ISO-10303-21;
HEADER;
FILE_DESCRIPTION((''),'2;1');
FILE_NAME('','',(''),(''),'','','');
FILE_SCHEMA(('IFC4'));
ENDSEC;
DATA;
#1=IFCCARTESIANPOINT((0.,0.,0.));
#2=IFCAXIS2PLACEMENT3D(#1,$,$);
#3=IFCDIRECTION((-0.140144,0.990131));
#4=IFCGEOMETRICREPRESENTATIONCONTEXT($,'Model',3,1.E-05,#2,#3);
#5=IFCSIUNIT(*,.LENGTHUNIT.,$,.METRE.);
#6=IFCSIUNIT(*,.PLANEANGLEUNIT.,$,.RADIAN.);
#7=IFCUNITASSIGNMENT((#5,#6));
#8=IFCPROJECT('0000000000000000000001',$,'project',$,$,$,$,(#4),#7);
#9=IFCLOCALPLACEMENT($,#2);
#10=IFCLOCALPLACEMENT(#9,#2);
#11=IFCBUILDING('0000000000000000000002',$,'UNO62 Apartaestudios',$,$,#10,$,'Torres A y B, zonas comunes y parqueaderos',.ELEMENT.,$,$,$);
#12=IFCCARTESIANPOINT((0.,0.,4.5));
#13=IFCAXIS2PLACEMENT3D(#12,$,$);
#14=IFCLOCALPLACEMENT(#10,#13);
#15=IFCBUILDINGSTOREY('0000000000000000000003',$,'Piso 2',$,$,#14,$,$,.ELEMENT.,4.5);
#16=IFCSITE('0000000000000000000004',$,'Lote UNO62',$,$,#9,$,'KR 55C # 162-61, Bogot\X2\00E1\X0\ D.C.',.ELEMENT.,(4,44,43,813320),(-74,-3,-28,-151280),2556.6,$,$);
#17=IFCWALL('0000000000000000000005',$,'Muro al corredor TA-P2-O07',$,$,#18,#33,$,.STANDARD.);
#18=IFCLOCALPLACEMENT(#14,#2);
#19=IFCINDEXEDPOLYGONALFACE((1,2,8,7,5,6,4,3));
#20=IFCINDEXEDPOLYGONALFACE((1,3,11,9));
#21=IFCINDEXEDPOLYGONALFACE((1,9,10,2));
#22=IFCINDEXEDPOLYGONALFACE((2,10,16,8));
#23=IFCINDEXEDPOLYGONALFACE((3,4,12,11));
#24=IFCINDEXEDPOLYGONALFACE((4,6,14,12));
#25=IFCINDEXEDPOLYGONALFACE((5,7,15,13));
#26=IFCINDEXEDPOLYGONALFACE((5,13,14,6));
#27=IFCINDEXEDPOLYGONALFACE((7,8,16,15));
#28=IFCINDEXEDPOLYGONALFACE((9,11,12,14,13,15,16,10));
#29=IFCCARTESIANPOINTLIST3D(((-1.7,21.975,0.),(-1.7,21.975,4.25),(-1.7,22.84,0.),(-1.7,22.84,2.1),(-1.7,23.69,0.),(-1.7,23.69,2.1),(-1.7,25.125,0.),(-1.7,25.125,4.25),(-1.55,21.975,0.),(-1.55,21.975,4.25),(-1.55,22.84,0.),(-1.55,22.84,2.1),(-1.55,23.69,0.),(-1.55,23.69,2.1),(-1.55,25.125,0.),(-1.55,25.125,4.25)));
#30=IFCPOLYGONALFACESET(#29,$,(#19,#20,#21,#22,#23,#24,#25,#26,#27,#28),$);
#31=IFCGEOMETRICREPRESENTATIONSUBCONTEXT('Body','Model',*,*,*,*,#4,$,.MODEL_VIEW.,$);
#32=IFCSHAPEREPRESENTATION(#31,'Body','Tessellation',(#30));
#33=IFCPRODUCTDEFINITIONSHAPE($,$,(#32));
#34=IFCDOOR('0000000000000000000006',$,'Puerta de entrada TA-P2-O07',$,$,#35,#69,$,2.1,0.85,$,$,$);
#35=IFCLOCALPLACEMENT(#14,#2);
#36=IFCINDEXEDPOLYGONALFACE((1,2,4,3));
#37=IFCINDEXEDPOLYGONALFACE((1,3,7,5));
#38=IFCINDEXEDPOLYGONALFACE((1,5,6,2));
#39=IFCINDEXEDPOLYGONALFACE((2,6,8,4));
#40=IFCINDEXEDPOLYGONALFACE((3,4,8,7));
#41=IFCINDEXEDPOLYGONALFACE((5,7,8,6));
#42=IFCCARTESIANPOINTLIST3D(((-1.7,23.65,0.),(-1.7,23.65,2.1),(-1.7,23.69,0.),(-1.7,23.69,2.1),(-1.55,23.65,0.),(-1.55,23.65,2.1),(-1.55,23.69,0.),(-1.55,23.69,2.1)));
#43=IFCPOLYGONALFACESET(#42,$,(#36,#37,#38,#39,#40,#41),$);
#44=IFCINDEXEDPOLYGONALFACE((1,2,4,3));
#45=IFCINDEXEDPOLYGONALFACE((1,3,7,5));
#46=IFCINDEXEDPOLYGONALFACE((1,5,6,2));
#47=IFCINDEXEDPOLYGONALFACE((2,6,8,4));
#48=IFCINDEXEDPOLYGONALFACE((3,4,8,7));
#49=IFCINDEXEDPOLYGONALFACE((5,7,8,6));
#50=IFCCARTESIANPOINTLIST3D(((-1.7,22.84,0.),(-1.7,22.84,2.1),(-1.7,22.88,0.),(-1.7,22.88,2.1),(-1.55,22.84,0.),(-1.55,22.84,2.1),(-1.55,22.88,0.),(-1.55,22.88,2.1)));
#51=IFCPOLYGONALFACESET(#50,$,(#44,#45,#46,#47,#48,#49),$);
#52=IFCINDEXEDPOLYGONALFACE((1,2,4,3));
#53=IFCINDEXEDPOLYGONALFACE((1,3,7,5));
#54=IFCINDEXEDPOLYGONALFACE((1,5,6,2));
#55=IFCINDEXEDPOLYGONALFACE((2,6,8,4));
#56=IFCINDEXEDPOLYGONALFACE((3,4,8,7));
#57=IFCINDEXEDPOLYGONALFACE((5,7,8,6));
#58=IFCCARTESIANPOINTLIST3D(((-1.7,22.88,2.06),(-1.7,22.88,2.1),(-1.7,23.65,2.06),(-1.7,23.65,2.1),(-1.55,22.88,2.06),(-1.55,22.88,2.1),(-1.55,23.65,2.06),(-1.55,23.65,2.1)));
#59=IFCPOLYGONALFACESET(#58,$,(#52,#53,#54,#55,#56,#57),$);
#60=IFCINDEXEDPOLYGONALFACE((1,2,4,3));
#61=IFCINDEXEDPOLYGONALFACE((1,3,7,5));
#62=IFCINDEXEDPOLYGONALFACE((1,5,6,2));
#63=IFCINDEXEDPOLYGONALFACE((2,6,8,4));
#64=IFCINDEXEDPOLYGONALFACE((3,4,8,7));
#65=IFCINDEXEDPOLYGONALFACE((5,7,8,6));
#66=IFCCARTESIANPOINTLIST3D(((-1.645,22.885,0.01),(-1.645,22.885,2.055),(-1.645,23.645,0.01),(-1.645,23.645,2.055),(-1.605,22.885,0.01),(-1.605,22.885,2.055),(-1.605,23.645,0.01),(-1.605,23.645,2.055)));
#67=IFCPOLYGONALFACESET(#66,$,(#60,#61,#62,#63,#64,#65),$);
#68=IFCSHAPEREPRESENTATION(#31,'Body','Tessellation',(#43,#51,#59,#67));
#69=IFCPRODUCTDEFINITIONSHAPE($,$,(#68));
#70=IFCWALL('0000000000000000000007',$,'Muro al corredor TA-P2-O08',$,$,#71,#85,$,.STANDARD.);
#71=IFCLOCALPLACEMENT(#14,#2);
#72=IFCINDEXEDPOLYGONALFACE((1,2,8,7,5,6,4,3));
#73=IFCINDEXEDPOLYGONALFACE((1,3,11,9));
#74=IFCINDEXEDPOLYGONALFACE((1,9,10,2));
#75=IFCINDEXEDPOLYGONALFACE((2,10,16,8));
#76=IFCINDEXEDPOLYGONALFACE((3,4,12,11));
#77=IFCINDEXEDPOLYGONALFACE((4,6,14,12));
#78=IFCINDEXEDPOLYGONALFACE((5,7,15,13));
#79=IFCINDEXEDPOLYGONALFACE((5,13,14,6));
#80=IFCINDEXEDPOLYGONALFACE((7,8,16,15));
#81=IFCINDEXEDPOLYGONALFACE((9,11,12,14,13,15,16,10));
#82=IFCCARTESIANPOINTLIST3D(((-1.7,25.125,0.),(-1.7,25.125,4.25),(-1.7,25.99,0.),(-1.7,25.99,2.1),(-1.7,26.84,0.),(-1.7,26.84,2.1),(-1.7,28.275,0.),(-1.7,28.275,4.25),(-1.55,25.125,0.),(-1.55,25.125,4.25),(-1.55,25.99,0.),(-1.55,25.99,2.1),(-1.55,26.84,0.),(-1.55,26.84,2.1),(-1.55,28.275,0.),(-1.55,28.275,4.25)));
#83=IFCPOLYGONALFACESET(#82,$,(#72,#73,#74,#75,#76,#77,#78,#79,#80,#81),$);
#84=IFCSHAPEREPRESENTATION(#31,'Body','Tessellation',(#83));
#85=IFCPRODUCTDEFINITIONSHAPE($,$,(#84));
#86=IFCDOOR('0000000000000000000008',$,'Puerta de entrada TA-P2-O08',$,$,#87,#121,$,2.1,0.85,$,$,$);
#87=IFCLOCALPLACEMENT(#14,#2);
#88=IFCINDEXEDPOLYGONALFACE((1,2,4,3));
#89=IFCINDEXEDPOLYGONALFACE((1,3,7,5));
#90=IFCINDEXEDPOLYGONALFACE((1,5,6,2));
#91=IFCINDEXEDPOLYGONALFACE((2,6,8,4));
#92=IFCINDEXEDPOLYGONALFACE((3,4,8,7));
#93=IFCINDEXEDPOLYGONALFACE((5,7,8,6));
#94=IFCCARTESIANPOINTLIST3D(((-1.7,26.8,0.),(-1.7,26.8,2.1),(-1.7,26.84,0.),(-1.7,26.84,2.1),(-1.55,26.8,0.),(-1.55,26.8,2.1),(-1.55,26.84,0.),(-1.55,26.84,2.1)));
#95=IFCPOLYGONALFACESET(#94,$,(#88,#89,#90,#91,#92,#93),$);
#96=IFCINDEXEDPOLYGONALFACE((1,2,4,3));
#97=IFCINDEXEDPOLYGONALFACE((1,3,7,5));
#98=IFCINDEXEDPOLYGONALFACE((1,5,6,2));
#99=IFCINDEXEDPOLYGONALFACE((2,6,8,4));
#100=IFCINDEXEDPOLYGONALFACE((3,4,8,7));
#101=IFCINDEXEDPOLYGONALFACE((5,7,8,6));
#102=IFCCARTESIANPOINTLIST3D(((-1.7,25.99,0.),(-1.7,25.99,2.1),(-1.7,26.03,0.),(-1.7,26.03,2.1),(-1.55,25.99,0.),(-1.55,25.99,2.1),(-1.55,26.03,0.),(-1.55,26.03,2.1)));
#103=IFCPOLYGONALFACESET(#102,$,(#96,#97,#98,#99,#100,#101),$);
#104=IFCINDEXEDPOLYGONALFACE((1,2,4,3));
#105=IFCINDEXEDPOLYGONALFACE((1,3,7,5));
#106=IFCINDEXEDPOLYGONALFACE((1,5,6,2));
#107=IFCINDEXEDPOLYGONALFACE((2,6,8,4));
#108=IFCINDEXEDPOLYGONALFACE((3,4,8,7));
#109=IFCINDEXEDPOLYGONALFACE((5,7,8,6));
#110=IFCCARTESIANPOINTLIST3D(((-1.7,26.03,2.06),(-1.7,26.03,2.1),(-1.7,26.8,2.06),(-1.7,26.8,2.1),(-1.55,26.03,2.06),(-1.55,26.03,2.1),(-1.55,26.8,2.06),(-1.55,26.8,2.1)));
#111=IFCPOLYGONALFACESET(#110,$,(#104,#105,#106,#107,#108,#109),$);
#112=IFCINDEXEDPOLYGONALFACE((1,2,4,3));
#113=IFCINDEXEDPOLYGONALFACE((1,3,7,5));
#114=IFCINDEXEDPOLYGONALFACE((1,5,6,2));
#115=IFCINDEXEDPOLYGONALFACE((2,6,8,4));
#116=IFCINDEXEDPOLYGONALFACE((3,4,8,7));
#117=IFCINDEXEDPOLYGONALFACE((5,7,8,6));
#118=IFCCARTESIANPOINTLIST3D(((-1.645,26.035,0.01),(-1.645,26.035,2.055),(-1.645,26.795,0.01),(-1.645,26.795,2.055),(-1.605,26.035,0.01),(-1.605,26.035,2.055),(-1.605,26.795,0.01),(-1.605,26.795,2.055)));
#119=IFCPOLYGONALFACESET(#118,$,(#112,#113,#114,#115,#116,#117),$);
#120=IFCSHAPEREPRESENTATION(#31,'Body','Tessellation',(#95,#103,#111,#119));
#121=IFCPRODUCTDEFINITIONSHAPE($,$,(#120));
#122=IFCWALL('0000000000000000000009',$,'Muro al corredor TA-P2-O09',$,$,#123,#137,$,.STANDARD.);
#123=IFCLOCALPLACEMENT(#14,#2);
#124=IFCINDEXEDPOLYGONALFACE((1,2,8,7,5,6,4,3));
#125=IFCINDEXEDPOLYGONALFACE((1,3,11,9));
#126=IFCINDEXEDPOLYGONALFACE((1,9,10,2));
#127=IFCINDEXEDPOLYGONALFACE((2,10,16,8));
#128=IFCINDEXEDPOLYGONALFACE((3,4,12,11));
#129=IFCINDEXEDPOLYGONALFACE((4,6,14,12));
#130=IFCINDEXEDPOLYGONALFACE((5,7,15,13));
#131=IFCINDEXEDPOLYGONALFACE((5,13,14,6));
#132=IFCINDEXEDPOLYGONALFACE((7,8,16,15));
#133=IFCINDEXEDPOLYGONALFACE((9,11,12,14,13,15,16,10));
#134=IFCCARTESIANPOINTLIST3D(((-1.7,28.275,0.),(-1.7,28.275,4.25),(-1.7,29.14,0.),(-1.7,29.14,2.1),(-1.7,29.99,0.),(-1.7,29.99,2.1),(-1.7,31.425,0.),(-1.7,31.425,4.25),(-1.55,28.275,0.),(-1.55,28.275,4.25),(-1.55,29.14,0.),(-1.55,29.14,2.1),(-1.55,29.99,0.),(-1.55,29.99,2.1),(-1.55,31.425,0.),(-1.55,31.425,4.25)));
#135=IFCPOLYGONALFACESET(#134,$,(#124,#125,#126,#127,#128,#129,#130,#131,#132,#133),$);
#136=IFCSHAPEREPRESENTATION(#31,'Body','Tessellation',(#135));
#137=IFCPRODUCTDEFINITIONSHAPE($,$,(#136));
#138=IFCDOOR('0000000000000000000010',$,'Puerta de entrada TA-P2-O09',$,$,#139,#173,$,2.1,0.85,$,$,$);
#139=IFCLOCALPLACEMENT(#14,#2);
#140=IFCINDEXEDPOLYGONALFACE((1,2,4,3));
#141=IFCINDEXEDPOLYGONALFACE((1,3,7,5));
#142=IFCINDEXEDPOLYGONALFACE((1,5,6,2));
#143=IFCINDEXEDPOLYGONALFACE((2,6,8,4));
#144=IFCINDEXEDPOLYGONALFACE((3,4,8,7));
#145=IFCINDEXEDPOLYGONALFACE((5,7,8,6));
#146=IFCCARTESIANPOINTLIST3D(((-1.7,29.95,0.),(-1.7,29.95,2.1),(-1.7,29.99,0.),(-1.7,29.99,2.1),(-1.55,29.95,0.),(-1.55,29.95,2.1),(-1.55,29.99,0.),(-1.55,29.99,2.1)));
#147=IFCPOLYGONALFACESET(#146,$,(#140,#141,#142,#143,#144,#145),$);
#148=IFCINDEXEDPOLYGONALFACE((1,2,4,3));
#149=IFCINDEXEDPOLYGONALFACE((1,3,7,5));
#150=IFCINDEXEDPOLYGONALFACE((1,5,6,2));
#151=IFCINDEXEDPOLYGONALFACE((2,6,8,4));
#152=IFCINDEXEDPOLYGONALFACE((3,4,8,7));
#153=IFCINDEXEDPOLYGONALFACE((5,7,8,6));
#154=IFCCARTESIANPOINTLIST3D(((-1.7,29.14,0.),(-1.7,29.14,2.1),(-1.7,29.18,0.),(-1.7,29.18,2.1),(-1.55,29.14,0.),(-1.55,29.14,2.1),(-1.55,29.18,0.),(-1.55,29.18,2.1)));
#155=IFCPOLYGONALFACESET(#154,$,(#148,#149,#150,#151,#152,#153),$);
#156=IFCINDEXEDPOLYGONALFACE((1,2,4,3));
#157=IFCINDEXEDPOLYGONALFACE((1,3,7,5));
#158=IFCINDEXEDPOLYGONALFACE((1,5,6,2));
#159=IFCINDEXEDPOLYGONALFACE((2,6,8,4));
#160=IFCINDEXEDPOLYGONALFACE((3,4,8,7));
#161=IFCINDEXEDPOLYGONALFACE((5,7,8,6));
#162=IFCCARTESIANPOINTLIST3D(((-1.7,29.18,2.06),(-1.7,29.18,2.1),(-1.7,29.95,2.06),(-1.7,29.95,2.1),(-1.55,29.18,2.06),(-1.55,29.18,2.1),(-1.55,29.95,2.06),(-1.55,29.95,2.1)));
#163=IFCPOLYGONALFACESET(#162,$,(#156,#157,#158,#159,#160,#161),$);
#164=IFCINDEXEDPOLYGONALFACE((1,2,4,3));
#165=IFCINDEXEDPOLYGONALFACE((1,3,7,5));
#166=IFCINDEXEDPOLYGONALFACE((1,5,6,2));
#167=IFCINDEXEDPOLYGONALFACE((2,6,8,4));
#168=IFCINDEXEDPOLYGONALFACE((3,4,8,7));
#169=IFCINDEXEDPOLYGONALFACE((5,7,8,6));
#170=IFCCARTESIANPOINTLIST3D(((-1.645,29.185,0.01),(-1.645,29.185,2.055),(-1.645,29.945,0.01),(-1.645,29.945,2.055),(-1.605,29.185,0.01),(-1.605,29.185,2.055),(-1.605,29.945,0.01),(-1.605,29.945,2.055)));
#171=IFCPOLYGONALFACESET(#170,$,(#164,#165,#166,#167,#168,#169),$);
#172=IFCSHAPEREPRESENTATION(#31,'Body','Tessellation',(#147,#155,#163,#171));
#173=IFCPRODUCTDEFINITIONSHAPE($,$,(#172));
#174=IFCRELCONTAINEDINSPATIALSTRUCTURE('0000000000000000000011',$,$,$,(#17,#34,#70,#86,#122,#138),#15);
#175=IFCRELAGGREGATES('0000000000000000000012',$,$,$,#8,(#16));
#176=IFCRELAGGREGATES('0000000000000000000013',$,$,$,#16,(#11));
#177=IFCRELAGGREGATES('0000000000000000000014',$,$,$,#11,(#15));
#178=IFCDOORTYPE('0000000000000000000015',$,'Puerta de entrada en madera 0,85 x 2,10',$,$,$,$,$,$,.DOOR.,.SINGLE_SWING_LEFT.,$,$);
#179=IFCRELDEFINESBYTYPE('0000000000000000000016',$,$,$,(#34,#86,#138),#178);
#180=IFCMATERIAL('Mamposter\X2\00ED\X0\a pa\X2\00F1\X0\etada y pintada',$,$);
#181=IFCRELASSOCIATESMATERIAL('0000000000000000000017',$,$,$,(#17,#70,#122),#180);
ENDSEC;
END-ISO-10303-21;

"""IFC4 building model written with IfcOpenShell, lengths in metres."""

from ifc_helpers import new_model, si_unit, direction, frame, frame_2d, origin, place, context, subcontext, project, spatial, rectangle, extrude, source, transform, mapped, material, type_object, type_shapes, element, fill, save


model = new_model("IFC4")

# Units and contexts
model_context = context("Model", 3, precision=1e-05, world=origin(), true_north=direction((-0.140144, 0.990131)))
body_context = subcontext(model_context, "Body", "Model", "MODEL_VIEW")
ifc_project = project(units=[si_unit("LENGTHUNIT", "METRE"), si_unit("PLANEANGLEUNIT", "RADIAN")], contexts=[model_context])

# Site, building, storey
site_placement = place(None, origin())
site = spatial("IfcSite", under=ifc_project, at=site_placement, Name="Lote UNO62", LongName="KR 55C # 162-61, Bogotá D.C.", CompositionType="ELEMENT", RefLatitude=(4, 44, 43, 813320), RefLongitude=(-74, -3, -28, -151280), RefElevation=2556.6)
building_placement = place(site_placement, origin())
building = spatial("IfcBuilding", under=site, at=building_placement, Name="UNO62 Apartaestudios", LongName="Torres A y B, zonas comunes y parqueaderos", CompositionType="ELEMENT")
storey_placement = place(building_placement, frame((0.0, 0.0, 4.5)))
storey = spatial("IfcBuildingStorey", under=building, at=storey_placement, Name="Piso 2", CompositionType="ELEMENT", Elevation=4.5)

# Walls, openings, doors
ifc_material = material(Name="Mampostería pañetada y pintada")
door_type = type_object("IfcDoorType", Name="Puerta de entrada en madera 0,85 x 2,10", OperationType="SINGLE_SWING_LEFT", PredefinedType="DOOR")
shared_shape = source(origin(), body_context, "Body", "SweptSolid", [
    extrude(rectangle(XDim=0.15, YDim=0.04, at=frame_2d((-0.075, 1.38))), origin(), (0.0, 0.0, 1.0), 2.1),
    extrude(rectangle(XDim=0.15, YDim=0.04, at=frame_2d((-0.075, 2.19))), origin(), (0.0, 0.0, 1.0), 2.1),
    extrude(rectangle(XDim=0.15, YDim=0.77, at=frame_2d((-0.075, 1.785))), frame((0.0, 0.0, 2.06)), (0.0, 0.0, 1.0), 0.04),
    extrude(rectangle(XDim=0.04, YDim=0.76, at=frame_2d((-0.075, 1.785))), frame((0.0, 0.0, 0.01)), (0.0, 0.0, 1.0), 2.045),
])
type_shapes(door_type, [shared_shape])
wall_1_placement = place(storey_placement, origin())
wall_1 = element("IfcWall", 1, at=wall_1_placement, inside=storey, material=ifc_material, Name="Muro al corredor TA-P2-O07", PredefinedType="STANDARD", context=body_context, shape_type="SweptSolid", body=[
    extrude(rectangle(XDim=0.15, YDim=3.15, at=frame_2d((-1.625, 23.55))), origin(), (0.0, 0.0, 1.0), 4.25),
])
opening_1_placement = place(wall_1_placement, origin())
opening_1 = element("IfcOpeningElement", 2, at=opening_1_placement, cuts=wall_1, PredefinedType="OPENING", context=body_context, shape_type="SweptSolid", body=[
    extrude(rectangle(XDim=0.25, YDim=0.85, at=frame_2d((-1.625, 23.265))), origin(), (0.0, 0.0, 1.0), 2.1),
])
placement_1 = place(storey_placement, frame((-1.7, 25.05, 0.0), z_axis=(0.0, 0.0, 1.0), x_axis=(-1.0, 0.0, 0.0)))
door_1_placement = place(placement_1, origin())
door_1 = element("IfcDoor", 3, at=door_1_placement, inside=storey, type_object=door_type, Name="Puerta de entrada TA-P2-O07", OverallHeight=2.1, OverallWidth=0.85, context=body_context, shape_type="MappedRepresentation", body=[
    mapped(shared_shape, transform((0.0, 0.0, 0.0))),
])
fill(opening_1, door_1)
wall_2_placement = place(storey_placement, origin())
wall_2 = element("IfcWall", 4, at=wall_2_placement, inside=storey, material=ifc_material, Name="Muro al corredor TA-P2-O08", PredefinedType="STANDARD", context=body_context, shape_type="SweptSolid", body=[
    extrude(rectangle(XDim=0.15, YDim=3.15, at=frame_2d((-1.625, 26.7))), origin(), (0.0, 0.0, 1.0), 4.25),
])
opening_2_placement = place(wall_2_placement, origin())
opening_2 = element("IfcOpeningElement", 5, at=opening_2_placement, cuts=wall_2, PredefinedType="OPENING", context=body_context, shape_type="SweptSolid", body=[
    extrude(rectangle(XDim=0.25, YDim=0.85, at=frame_2d((-1.625, 26.415))), origin(), (0.0, 0.0, 1.0), 2.1),
])
placement_2 = place(storey_placement, frame((-1.7, 28.2, 0.0), z_axis=(0.0, 0.0, 1.0), x_axis=(-1.0, 0.0, 0.0)))
door_2_placement = place(placement_2, origin())
door_2 = element("IfcDoor", 6, at=door_2_placement, inside=storey, type_object=door_type, Name="Puerta de entrada TA-P2-O08", OverallHeight=2.1, OverallWidth=0.85, context=body_context, shape_type="MappedRepresentation", body=[
    mapped(shared_shape, transform((0.0, 0.0, 0.0))),
])
fill(opening_2, door_2)
wall_3_placement = place(storey_placement, origin())
wall_3 = element("IfcWall", 7, at=wall_3_placement, inside=storey, material=ifc_material, Name="Muro al corredor TA-P2-O09", PredefinedType="STANDARD", context=body_context, shape_type="SweptSolid", body=[
    extrude(rectangle(XDim=0.15, YDim=3.15, at=frame_2d((-1.625, 29.85))), origin(), (0.0, 0.0, 1.0), 4.25),
])
opening_3_placement = place(wall_3_placement, origin())
opening_3 = element("IfcOpeningElement", 8, at=opening_3_placement, cuts=wall_3, PredefinedType="OPENING", context=body_context, shape_type="SweptSolid", body=[
    extrude(rectangle(XDim=0.25, YDim=0.85, at=frame_2d((-1.625, 29.565))), origin(), (0.0, 0.0, 1.0), 2.1),
])
placement_3 = place(storey_placement, frame((-1.7, 31.35, 0.0), z_axis=(0.0, 0.0, 1.0), x_axis=(-1.0, 0.0, 0.0)))
door_3_placement = place(placement_3, origin())
door_3 = element("IfcDoor", 9, at=door_3_placement, inside=storey, type_object=door_type, Name="Puerta de entrada TA-P2-O09", OverallHeight=2.1, OverallWidth=0.85, context=body_context, shape_type="MappedRepresentation", body=[
    mapped(shared_shape, transform((0.0, 0.0, 0.0))),
])
fill(opening_3, door_3)

save(model, "model.ifc")
